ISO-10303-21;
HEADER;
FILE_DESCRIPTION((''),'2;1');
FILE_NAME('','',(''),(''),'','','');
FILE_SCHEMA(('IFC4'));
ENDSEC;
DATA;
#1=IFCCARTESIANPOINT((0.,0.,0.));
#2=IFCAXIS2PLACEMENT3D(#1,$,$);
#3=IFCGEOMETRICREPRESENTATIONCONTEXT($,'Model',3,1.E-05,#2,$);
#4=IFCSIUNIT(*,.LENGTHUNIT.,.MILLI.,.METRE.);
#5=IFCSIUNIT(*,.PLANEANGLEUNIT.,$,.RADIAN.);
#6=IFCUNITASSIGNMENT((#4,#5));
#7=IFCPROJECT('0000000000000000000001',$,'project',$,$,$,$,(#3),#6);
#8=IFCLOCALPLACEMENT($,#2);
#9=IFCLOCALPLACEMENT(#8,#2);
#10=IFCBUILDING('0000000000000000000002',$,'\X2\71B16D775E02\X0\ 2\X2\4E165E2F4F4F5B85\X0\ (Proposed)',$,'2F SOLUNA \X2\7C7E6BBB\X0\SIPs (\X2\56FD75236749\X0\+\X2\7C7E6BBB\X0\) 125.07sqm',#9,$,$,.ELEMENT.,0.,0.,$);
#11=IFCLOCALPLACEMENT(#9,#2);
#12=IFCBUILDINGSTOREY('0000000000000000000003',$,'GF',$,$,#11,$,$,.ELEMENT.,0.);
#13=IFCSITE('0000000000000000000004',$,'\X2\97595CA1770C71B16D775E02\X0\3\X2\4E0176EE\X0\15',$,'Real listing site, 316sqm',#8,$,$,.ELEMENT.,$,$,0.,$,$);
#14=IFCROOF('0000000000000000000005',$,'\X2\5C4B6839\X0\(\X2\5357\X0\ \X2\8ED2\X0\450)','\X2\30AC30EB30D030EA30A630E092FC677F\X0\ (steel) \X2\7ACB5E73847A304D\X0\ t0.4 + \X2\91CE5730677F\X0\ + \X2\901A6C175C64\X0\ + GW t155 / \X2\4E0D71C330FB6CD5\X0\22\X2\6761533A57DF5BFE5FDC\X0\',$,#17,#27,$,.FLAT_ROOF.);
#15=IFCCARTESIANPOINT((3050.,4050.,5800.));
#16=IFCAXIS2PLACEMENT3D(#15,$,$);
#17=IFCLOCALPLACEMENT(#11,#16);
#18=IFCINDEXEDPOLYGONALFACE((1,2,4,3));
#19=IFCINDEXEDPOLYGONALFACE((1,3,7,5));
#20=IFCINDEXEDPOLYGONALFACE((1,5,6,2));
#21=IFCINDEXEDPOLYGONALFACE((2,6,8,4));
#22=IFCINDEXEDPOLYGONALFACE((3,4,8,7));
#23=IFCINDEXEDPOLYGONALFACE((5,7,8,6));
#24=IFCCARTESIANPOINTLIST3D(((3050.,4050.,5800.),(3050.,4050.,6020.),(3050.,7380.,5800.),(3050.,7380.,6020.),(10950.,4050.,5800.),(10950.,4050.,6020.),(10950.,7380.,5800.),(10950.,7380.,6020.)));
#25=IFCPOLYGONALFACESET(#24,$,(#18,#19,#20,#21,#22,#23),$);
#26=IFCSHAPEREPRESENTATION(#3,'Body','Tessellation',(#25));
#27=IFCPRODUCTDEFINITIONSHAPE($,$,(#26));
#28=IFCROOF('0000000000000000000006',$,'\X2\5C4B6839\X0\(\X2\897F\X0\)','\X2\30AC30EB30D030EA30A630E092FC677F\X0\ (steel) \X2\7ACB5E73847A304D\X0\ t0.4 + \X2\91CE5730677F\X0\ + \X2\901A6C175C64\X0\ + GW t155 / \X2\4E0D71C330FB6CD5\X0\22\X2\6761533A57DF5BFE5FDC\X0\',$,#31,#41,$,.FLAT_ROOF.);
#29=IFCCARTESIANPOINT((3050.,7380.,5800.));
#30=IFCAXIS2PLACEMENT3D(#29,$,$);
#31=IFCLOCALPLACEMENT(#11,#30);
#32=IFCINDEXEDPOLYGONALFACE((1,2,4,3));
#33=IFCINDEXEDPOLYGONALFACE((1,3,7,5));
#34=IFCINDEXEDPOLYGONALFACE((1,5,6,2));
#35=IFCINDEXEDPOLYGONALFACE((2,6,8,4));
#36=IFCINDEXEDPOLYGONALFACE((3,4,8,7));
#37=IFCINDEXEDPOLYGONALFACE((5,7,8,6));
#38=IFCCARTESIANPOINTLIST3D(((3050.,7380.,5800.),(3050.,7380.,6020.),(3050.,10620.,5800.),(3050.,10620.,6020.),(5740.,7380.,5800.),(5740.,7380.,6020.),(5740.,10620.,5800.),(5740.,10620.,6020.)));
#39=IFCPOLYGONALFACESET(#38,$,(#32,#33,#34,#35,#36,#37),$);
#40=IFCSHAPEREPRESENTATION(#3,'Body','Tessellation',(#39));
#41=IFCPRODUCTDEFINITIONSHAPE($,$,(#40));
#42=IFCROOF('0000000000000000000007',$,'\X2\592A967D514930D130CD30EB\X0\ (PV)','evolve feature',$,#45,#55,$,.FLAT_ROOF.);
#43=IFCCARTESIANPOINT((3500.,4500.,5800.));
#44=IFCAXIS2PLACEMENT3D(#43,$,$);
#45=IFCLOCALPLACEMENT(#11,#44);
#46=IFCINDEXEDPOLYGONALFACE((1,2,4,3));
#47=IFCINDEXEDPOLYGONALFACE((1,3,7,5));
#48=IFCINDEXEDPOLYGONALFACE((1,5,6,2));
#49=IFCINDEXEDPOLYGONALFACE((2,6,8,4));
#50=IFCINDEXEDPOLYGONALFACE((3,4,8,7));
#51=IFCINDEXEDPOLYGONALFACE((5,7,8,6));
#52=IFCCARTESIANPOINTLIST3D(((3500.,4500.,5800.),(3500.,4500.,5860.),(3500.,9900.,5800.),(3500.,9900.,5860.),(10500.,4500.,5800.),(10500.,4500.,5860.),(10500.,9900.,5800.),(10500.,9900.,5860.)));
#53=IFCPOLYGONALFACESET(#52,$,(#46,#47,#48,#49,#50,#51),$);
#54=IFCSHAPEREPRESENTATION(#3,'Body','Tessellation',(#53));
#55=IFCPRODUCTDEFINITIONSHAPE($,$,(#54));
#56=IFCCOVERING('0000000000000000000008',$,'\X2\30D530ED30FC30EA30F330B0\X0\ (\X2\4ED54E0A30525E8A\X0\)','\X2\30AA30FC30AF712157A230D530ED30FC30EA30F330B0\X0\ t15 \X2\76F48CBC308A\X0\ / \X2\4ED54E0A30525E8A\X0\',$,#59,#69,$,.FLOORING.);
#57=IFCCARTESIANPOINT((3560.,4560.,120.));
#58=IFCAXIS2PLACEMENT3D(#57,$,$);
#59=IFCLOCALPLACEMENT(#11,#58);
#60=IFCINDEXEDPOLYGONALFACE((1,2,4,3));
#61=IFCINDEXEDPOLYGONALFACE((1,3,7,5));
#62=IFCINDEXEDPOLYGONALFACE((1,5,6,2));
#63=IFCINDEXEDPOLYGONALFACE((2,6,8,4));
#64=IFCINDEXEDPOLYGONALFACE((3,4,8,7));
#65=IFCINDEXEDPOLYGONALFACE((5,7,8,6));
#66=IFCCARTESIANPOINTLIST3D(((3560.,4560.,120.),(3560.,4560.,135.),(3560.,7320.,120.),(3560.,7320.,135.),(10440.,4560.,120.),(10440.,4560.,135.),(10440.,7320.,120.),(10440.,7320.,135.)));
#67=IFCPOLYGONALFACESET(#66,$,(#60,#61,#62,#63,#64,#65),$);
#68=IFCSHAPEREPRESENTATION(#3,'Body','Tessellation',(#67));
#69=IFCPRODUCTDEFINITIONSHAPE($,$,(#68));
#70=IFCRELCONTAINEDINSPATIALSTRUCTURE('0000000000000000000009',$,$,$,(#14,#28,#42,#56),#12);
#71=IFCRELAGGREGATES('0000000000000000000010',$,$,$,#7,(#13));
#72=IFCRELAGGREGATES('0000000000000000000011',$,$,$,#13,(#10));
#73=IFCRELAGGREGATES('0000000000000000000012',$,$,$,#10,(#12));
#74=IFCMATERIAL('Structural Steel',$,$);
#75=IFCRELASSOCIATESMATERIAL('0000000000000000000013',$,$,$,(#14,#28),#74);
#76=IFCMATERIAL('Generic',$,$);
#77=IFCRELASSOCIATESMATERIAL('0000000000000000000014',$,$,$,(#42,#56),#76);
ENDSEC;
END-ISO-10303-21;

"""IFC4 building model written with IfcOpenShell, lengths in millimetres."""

from ifc_helpers import new_model, si_unit, frame, frame_2d, origin, place, context, project, spatial, rectangle, extrude, material, element, save


model = new_model("IFC4")

# Units and contexts
model_context = context("Model", 3, precision=1e-05, world=origin())
ifc_project = project(units=[si_unit("LENGTHUNIT", "METRE", prefix="MILLI"), si_unit("PLANEANGLEUNIT", "RADIAN")], contexts=[model_context])

# Site, building, storey
site_placement = place(None, origin())
site = spatial("IfcSite", under=ifc_project, at=site_placement, Name="静岡県熱海市3丁目15", ObjectType="Real listing site, 316sqm", CompositionType="ELEMENT", RefElevation=0.0)
building_placement = place(site_placement, origin())
building = spatial("IfcBuilding", under=site, at=building_placement, Name="熱海市 2世帯住宅 (Proposed)", ObjectType="2F SOLUNA 籾殻SIPs (国産杉+籾殻) 125.07sqm", CompositionType="ELEMENT", ElevationOfRefHeight=0.0, ElevationOfTerrain=0.0)
storey_placement = place(building_placement, origin())
storey = spatial("IfcBuildingStorey", under=building, at=storey_placement, Name="GF", CompositionType="ELEMENT", Elevation=0.0)

# Shared definitions
ifc_material_1 = material(Name="Generic")

# Roofs
ifc_material_2 = material(Name="Structural Steel")
roof_1_placement = place(storey_placement, frame((3050.0, 4050.0, 5800.0)))
element("IfcRoof", 1, at=roof_1_placement, inside=storey, material=ifc_material_2, Name="屋根(南 軒450)", Description="ガルバリウム鋼板 (steel) 立平葺き t0.4 + 野地板 + 通気層 + GW t155 / 不燃・法22条区域対応", PredefinedType="FLAT_ROOF", context=model_context, shape_type="SweptSolid", body=[
    extrude(rectangle(XDim=7900.0, YDim=3330.0, at=frame_2d((3950.0, 1665.0))), frame((3050.0, 4050.0, 5800.0)), (0.0, 0.0, 1.0), 220.0),
])
roof_2_placement = place(storey_placement, frame((3050.0, 7380.0, 5800.0)))
element("IfcRoof", 2, at=roof_2_placement, inside=storey, material=ifc_material_2, Name="屋根(西)", Description="ガルバリウム鋼板 (steel) 立平葺き t0.4 + 野地板 + 通気層 + GW t155 / 不燃・法22条区域対応", PredefinedType="FLAT_ROOF", context=model_context, shape_type="SweptSolid", body=[
    extrude(rectangle(XDim=2690.0, YDim=3240.0, at=frame_2d((1345.0, 1620.0))), frame((3050.0, 7380.0, 5800.0)), (0.0, 0.0, 1.0), 220.0),
])
roof_3_placement = place(storey_placement, frame((3500.0, 4500.0, 5800.0)))
element("IfcRoof", 3, at=roof_3_placement, inside=storey, material=ifc_material_1, Name="太陽光パネル (PV)", Description="evolve feature", PredefinedType="FLAT_ROOF", context=model_context, shape_type="SweptSolid", body=[
    extrude(rectangle(XDim=7000.0, YDim=5400.0, at=frame_2d((3500.0, 2700.0))), frame((3500.0, 4500.0, 5800.0)), (0.0, 0.0, 1.0), 60.0),
])

# Covering
covering_placement = place(storey_placement, frame((3560.0, 4560.0, 120.0)))
element("IfcCovering", 4, at=covering_placement, inside=storey, material=ifc_material_1, Name="フローリング (仕上げ床)", Description="オーク無垢フローリング t15 直貼り / 仕上げ床", PredefinedType="FLOORING", context=model_context, shape_type="SweptSolid", body=[
    extrude(rectangle(XDim=6880.0, YDim=2760.0, at=frame_2d((3440.0, 1380.0))), frame((3560.0, 4560.0, 120.0)), (0.0, 0.0, 1.0), 15.0),
])

save(model, "model.ifc")
